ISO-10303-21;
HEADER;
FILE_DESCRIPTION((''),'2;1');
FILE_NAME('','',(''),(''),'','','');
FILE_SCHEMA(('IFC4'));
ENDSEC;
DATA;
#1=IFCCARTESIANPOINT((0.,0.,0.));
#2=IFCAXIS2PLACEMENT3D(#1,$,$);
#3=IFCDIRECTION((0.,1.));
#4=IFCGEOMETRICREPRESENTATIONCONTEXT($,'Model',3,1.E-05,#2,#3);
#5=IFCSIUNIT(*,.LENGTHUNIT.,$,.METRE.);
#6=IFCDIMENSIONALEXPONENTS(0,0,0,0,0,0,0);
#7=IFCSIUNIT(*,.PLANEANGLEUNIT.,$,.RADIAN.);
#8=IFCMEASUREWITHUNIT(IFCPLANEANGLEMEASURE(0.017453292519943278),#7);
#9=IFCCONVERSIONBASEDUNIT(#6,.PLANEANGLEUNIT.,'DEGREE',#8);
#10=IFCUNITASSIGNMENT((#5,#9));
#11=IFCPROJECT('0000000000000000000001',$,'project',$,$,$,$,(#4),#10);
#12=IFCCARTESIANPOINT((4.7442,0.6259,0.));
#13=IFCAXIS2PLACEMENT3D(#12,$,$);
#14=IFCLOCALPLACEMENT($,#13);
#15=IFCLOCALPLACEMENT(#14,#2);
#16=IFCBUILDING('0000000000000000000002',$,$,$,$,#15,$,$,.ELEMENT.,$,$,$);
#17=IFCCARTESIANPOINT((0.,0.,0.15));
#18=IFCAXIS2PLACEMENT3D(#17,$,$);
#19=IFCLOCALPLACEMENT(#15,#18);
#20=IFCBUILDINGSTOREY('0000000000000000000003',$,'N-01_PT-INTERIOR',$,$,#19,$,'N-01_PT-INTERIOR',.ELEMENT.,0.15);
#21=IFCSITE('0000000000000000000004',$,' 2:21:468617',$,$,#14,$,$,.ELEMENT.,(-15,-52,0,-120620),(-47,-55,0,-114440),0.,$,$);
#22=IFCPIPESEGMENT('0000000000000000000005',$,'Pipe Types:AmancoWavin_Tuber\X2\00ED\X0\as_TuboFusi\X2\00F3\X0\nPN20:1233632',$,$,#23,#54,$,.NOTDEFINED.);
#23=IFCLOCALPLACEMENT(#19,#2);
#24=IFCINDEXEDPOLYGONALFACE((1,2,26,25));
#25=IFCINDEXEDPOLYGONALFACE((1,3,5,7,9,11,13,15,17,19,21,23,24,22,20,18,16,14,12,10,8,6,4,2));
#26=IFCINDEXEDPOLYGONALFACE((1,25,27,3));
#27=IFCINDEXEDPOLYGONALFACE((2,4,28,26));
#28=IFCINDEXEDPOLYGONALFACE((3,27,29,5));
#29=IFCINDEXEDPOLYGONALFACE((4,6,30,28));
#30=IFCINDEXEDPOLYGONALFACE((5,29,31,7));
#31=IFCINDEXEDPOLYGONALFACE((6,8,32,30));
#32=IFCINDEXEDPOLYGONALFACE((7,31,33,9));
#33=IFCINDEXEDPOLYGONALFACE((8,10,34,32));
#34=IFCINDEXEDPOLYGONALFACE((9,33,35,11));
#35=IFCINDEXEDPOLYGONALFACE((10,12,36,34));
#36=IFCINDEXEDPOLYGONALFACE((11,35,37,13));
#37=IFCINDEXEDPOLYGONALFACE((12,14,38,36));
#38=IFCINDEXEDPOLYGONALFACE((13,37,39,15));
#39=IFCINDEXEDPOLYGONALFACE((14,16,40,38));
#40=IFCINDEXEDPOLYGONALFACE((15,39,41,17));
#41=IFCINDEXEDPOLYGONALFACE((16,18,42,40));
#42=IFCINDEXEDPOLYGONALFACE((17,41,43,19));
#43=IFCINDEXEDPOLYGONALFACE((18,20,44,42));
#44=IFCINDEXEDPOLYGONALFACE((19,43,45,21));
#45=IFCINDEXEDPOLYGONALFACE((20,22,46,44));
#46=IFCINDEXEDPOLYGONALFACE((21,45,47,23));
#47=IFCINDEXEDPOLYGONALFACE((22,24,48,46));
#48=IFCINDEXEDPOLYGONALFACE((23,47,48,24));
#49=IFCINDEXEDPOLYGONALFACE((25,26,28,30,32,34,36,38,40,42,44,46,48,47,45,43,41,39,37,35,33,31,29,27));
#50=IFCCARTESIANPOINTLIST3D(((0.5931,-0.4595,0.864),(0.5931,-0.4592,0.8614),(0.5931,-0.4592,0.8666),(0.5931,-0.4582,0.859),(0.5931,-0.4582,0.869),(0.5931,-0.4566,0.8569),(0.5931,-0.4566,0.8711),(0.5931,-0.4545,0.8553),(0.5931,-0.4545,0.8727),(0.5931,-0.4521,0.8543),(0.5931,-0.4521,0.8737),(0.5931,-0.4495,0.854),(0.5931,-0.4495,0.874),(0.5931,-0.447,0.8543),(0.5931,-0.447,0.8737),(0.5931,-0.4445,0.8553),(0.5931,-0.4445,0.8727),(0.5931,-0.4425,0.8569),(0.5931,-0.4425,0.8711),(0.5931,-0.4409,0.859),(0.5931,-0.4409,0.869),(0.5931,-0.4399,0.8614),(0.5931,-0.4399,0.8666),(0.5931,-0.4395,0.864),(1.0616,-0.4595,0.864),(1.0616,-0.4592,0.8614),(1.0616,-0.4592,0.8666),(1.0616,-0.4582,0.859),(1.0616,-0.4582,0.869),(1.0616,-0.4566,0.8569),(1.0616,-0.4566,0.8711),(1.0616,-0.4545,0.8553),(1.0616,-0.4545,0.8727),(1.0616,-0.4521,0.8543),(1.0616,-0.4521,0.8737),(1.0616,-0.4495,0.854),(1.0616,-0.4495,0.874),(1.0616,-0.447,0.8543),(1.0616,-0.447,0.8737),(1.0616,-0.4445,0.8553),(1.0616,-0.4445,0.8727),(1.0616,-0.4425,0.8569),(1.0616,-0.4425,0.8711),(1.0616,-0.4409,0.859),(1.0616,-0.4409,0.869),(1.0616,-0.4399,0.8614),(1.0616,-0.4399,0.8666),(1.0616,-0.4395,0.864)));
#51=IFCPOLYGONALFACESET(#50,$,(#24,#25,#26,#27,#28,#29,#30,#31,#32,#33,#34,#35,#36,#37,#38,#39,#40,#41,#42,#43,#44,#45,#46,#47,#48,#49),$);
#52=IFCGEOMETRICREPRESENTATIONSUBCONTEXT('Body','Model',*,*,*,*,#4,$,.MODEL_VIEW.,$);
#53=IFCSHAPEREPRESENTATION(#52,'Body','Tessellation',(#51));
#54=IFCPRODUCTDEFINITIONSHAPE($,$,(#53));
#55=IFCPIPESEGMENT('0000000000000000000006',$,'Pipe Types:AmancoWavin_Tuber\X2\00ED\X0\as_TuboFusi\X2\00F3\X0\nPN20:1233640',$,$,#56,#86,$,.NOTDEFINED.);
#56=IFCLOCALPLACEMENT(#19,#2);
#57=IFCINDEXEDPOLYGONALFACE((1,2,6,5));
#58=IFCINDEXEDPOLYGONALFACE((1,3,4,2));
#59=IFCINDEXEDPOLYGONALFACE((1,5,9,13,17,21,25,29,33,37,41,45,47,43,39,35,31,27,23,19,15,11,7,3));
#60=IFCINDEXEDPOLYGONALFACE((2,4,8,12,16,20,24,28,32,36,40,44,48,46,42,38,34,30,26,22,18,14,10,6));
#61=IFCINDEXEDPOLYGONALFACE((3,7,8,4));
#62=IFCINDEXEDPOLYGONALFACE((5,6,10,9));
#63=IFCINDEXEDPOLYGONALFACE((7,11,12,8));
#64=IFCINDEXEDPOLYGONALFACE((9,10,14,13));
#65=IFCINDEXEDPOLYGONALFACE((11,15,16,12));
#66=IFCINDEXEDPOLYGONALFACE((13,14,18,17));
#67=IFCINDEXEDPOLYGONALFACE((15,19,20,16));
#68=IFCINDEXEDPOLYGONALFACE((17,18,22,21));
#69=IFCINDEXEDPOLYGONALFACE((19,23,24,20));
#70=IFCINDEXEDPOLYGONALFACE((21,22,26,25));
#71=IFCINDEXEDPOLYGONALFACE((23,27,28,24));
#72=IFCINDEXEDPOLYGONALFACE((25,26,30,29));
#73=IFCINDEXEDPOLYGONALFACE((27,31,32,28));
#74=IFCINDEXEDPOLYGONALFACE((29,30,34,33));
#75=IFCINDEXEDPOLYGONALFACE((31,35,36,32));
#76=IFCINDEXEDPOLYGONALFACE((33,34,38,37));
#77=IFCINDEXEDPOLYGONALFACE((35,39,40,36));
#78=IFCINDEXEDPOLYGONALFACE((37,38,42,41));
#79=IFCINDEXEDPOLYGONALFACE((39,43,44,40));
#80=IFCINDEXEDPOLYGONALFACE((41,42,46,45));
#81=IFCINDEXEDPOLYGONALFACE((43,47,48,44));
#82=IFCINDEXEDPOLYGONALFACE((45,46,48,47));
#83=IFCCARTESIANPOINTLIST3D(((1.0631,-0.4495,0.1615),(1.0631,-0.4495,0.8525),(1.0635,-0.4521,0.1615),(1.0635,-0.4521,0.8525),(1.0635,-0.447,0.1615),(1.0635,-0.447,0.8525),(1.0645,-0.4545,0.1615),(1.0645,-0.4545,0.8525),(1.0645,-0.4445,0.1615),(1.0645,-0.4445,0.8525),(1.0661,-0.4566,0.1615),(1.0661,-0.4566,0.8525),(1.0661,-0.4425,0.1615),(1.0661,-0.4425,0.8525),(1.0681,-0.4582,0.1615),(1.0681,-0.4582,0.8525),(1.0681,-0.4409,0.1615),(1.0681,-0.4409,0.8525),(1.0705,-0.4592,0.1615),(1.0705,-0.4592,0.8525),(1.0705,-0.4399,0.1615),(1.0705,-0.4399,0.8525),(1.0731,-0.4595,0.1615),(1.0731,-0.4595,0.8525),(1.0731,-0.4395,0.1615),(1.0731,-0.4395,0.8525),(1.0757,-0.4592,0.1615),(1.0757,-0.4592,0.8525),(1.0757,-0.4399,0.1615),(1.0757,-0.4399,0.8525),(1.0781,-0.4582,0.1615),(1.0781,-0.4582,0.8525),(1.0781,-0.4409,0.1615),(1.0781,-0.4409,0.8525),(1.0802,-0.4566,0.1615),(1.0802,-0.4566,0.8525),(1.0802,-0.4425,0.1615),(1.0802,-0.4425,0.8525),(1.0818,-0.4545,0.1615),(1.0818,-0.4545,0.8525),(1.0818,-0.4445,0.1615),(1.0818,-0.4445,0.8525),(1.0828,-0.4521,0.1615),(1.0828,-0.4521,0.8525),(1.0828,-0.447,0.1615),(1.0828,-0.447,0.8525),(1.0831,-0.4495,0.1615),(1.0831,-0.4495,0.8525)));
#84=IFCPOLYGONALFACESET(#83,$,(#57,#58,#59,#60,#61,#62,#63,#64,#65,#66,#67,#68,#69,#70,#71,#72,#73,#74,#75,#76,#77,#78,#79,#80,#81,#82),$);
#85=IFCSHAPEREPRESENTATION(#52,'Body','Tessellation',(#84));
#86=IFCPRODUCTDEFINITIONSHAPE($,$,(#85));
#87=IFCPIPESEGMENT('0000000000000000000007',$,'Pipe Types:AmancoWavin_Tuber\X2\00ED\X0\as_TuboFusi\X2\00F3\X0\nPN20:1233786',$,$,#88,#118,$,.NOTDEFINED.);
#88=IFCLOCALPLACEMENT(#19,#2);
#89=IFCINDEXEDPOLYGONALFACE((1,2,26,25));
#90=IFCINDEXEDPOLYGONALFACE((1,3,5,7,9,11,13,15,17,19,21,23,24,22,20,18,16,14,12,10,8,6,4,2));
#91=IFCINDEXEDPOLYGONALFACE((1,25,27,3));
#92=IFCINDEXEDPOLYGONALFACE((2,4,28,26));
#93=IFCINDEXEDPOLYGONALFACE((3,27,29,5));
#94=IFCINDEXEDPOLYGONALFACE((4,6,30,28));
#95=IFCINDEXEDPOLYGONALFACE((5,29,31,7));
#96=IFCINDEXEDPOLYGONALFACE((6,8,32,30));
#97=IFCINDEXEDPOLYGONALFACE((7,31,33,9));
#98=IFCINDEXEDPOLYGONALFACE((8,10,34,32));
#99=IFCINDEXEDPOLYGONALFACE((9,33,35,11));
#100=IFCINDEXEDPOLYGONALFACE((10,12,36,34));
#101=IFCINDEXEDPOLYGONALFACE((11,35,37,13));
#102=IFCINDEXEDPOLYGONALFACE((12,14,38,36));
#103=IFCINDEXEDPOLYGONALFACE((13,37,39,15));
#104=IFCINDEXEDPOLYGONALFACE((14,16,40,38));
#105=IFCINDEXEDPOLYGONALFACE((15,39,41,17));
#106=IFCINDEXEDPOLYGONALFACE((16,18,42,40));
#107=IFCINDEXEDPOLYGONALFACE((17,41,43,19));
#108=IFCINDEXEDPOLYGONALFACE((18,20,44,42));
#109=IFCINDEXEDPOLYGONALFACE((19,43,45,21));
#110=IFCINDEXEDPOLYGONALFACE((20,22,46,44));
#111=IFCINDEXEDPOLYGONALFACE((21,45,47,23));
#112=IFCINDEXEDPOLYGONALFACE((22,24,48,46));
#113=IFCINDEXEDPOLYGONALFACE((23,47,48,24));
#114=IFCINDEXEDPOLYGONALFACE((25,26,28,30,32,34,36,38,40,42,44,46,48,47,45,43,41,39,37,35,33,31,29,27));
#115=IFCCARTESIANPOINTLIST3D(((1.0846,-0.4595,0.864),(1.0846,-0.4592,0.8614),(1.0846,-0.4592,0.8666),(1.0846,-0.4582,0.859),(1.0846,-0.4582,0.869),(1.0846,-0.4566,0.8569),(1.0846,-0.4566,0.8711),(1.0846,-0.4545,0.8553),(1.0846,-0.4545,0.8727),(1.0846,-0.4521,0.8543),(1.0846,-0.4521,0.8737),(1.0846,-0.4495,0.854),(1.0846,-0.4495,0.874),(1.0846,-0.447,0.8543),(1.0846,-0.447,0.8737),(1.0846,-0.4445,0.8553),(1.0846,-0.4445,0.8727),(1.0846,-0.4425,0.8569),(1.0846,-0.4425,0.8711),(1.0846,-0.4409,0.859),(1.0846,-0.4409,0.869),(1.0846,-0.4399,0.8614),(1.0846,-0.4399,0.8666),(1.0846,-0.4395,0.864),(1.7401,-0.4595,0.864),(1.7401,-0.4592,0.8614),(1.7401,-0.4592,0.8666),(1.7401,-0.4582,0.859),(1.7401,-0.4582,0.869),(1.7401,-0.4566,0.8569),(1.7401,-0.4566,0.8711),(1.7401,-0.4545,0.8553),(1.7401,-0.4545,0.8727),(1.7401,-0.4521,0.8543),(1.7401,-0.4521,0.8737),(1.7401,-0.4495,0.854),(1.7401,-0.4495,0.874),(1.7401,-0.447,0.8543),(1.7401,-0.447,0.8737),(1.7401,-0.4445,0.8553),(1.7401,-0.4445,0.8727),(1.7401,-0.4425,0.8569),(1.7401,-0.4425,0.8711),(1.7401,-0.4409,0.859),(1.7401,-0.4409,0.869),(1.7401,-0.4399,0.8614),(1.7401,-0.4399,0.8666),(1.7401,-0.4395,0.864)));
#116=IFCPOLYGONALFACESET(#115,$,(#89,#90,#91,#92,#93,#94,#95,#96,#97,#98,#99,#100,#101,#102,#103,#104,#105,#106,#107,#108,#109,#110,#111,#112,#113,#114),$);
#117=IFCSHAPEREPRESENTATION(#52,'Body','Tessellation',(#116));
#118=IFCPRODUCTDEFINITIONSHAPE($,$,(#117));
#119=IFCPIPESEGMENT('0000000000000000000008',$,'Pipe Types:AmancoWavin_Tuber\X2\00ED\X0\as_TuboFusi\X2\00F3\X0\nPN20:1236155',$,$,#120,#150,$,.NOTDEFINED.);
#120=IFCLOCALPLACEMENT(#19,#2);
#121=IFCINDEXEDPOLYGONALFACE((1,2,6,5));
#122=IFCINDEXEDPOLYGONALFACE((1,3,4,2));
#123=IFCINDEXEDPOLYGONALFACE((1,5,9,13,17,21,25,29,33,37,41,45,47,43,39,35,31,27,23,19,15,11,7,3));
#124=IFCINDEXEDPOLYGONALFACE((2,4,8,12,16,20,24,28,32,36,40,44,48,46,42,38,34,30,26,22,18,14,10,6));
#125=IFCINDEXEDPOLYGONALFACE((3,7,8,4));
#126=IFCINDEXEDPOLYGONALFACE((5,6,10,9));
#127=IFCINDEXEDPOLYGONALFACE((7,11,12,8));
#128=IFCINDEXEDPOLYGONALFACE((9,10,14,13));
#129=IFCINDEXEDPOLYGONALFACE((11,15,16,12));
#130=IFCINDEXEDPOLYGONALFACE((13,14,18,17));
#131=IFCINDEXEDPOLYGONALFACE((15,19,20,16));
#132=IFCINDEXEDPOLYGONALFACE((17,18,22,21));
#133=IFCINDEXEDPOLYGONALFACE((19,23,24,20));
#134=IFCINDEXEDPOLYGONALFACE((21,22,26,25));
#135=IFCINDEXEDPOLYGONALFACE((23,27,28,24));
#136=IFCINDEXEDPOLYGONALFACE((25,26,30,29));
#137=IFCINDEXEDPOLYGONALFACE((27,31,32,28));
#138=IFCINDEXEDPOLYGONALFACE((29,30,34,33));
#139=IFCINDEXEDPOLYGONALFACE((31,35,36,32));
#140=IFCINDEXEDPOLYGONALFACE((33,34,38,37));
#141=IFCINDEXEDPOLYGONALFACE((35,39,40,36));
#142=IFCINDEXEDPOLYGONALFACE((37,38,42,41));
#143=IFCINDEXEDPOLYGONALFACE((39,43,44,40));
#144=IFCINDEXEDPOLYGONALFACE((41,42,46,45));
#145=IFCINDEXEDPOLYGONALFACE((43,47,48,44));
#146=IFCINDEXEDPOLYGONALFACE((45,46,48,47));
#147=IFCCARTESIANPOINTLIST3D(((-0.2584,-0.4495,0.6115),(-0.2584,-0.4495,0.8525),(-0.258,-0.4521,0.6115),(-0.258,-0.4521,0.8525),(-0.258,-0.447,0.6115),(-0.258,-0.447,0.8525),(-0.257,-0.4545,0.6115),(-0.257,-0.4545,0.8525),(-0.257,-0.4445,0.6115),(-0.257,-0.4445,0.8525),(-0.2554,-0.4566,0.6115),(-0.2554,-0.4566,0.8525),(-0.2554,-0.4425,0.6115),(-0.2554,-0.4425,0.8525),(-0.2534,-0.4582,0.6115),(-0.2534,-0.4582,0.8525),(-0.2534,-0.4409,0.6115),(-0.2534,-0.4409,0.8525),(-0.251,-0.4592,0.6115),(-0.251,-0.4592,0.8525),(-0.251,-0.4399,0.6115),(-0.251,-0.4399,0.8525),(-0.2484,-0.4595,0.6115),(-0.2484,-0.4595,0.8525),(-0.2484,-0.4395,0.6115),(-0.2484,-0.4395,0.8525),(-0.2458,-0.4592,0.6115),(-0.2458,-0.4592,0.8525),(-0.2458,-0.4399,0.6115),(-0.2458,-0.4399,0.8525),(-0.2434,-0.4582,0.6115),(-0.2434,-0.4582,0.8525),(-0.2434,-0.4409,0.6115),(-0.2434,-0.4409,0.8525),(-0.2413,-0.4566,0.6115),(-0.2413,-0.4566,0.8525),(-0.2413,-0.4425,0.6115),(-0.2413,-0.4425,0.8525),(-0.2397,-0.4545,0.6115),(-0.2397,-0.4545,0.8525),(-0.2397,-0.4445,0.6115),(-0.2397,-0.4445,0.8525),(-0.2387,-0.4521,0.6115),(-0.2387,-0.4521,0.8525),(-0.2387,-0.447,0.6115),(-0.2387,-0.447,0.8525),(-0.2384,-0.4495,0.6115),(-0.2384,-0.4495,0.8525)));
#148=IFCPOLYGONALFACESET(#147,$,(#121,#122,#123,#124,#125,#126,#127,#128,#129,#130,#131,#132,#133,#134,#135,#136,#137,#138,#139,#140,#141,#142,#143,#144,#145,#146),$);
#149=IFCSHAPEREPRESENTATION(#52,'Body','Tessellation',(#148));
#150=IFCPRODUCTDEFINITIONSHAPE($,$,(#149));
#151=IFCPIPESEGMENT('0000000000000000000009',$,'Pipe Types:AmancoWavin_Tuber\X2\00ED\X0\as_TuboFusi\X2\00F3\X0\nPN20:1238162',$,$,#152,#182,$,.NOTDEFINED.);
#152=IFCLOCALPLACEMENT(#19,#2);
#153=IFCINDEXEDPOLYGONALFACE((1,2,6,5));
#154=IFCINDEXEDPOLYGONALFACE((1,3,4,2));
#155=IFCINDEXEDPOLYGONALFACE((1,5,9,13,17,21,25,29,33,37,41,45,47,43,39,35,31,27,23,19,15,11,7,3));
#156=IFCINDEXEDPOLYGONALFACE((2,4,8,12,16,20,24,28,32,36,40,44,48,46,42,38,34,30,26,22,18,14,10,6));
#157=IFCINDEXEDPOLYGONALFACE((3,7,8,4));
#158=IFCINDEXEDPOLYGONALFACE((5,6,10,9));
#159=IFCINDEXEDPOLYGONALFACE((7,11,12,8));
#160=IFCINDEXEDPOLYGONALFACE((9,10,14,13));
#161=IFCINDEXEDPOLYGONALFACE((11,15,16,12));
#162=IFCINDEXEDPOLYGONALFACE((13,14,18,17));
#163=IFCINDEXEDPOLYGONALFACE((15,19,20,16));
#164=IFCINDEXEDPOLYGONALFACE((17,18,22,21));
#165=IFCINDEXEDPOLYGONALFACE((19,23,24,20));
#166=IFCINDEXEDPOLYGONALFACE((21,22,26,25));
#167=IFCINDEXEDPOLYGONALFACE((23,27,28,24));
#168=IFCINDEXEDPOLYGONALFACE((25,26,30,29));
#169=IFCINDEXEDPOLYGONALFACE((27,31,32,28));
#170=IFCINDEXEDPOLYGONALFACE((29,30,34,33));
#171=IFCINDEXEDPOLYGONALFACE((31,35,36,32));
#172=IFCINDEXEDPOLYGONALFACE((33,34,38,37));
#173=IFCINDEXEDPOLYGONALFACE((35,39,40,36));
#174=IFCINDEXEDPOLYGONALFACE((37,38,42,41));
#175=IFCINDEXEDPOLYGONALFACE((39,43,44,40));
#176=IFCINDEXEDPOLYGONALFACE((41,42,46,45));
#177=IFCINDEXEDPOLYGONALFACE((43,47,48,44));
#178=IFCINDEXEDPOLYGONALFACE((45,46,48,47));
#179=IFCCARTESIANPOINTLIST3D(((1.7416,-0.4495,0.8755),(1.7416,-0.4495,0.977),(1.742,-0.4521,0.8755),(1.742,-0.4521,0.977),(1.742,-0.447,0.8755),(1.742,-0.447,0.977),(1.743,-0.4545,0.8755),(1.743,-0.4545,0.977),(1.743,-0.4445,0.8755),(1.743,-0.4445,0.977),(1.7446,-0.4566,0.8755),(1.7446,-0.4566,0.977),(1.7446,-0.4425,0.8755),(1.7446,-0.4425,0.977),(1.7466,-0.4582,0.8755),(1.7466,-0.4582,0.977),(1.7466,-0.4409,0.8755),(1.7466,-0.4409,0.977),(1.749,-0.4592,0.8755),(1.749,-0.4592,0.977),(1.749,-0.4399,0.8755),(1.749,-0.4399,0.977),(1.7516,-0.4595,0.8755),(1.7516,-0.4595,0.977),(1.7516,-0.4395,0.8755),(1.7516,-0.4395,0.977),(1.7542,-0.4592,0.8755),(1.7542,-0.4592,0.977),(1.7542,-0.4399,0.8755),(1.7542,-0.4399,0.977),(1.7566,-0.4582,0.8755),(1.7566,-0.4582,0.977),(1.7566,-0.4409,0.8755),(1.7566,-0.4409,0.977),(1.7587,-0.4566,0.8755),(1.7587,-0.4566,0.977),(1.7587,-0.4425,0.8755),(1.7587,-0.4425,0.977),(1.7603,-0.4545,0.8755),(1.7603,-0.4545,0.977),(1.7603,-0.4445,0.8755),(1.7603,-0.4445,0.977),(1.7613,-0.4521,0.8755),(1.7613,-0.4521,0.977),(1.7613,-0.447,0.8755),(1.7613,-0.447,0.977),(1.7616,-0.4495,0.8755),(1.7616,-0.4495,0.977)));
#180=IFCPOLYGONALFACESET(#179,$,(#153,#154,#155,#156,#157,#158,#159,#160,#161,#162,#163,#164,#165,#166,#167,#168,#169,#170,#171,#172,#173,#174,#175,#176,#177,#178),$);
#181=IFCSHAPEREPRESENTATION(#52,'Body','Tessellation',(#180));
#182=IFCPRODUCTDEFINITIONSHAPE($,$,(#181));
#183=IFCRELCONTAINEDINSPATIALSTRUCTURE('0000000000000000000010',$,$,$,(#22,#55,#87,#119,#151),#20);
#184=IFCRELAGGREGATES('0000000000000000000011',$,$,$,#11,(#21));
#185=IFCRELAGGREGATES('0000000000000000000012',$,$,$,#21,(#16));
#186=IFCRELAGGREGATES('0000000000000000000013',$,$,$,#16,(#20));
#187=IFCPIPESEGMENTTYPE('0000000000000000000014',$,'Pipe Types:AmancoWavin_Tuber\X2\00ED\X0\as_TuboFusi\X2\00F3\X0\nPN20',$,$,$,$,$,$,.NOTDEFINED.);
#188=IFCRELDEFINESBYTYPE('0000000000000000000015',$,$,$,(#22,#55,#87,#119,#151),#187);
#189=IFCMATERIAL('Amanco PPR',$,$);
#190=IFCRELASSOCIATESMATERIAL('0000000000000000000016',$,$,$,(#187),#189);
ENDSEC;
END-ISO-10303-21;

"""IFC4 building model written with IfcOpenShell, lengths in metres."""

from ifc_helpers import new_model, entity, si_unit, converted_unit, direction, frame, origin, place, context, subcontext, project, spatial, arc, indexed_curve, outline, extrude, material, type_object, element, save


model = new_model("IFC4")

# Units and contexts
model_context = context("Model", 3, precision=1e-05, world=origin(), true_north=direction((0.0, 1.0)))
body_context = subcontext(model_context, "Body", "Model", "MODEL_VIEW")
ifc_project = project(units=[si_unit("LENGTHUNIT", "METRE"), converted_unit("PLANEANGLEUNIT", "DEGREE", entity("IfcPlaneAngleMeasure", 0.017453292519943278), si_unit("PLANEANGLEUNIT", "RADIAN"), dimensions=[0, 0, 0, 0, 0, 0, 0])], contexts=[model_context])

# Site, building, storey
site_placement = place(None, frame((4.7442, 0.6259, 0.0)))
site = spatial("IfcSite", under=ifc_project, at=site_placement, Name=" 2:21:468617", CompositionType="ELEMENT", RefLatitude=(-15, -52, 0, -120620), RefLongitude=(-47, -55, 0, -114440), RefElevation=0.0)
building_placement = place(site_placement, origin())
building = spatial("IfcBuilding", under=site, at=building_placement, CompositionType="ELEMENT")
storey_placement = place(building_placement, frame((0.0, 0.0, 0.15)))
storey = spatial("IfcBuildingStorey", under=building, at=storey_placement, Name="N-01_PT-INTERIOR", LongName="N-01_PT-INTERIOR", CompositionType="ELEMENT", Elevation=0.15)

# Pipe segments
ifc_material_1 = material(Name="Amanco PPR")
pipe_segment_type_1 = type_object("IfcPipeSegmentType", Name="Pipe Types:AmancoWavin_Tuberías_TuboFusiónPN20", PredefinedType="NOTDEFINED", material=ifc_material_1)
pipe_segment_1_placement = place(storey_placement, origin())
element("IfcPipeSegment", 1, at=pipe_segment_1_placement, inside=storey, type_object=pipe_segment_type_1, Name="Pipe Types:AmancoWavin_Tuberías_TuboFusiónPN20:1233632", PredefinedType="NOTDEFINED", context=body_context, shape_type="SweptSolid", body=[
    extrude(outline(indexed_curve([(0.01, 0.0), (0.0071, 0.0071), (0.0, 0.01), (-0.0071, 0.0071), (-0.01, 0.0), (-0.0071, -0.0071), (0.0, -0.01), (0.0071, -0.0071)], segments=[arc(1, 2, 3), arc(3, 4, 5), arc(5, 6, 7), arc(7, 8, 1)], self_intersect=False)), frame((0.5931, -0.4495, 0.864), z_axis=(1.0, 0.0, 0.0), x_axis=(0.0, -1.0, 0.0)), (0.0, 0.0, 1.0), 0.4685),
])
pipe_segment_2_placement = place(storey_placement, origin())
element("IfcPipeSegment", 2, at=pipe_segment_2_placement, inside=storey, type_object=pipe_segment_type_1, Name="Pipe Types:AmancoWavin_Tuberías_TuboFusiónPN20:1233640", PredefinedType="NOTDEFINED", context=body_context, shape_type="SweptSolid", body=[
    extrude(outline(indexed_curve([(0.01, 0.0), (0.0071, 0.0071), (0.0, 0.01), (-0.0071, 0.0071), (-0.01, 0.0), (-0.0071, -0.0071), (0.0, -0.01), (0.0071, -0.0071)], segments=[arc(1, 2, 3), arc(3, 4, 5), arc(5, 6, 7), arc(7, 8, 1)], self_intersect=False)), frame((1.0731, -0.4495, 0.1615)), (0.0, 0.0, 1.0), 0.691),
])
pipe_segment_3_placement = place(storey_placement, origin())
element("IfcPipeSegment", 3, at=pipe_segment_3_placement, inside=storey, type_object=pipe_segment_type_1, Name="Pipe Types:AmancoWavin_Tuberías_TuboFusiónPN20:1233786", PredefinedType="NOTDEFINED", context=body_context, shape_type="SweptSolid", body=[
    extrude(outline(indexed_curve([(0.01, 0.0), (0.0071, 0.0071), (0.0, 0.01), (-0.0071, 0.0071), (-0.01, 0.0), (-0.0071, -0.0071), (0.0, -0.01), (0.0071, -0.0071)], segments=[arc(1, 2, 3), arc(3, 4, 5), arc(5, 6, 7), arc(7, 8, 1)], self_intersect=False)), frame((1.0846, -0.4495, 0.864), z_axis=(1.0, 0.0, 0.0), x_axis=(0.0, -1.0, 0.0)), (0.0, 0.0, 1.0), 0.6555),
])
pipe_segment_4_placement = place(storey_placement, origin())
element("IfcPipeSegment", 4, at=pipe_segment_4_placement, inside=storey, type_object=pipe_segment_type_1, Name="Pipe Types:AmancoWavin_Tuberías_TuboFusiónPN20:1236155", PredefinedType="NOTDEFINED", context=body_context, shape_type="SweptSolid", body=[
    extrude(outline(indexed_curve([(0.01, 0.0), (0.0071, 0.0071), (0.0, 0.01), (-0.0071, 0.0071), (-0.01, 0.0), (-0.0071, -0.0071), (0.0, -0.01), (0.0071, -0.0071)], segments=[arc(1, 2, 3), arc(3, 4, 5), arc(5, 6, 7), arc(7, 8, 1)], self_intersect=False)), frame((-0.2484, -0.4495, 0.6115)), (0.0, 0.0, 1.0), 0.241),
])
pipe_segment_5_placement = place(storey_placement, origin())
element("IfcPipeSegment", 5, at=pipe_segment_5_placement, inside=storey, type_object=pipe_segment_type_1, Name="Pipe Types:AmancoWavin_Tuberías_TuboFusiónPN20:1238162", PredefinedType="NOTDEFINED", context=body_context, shape_type="SweptSolid", body=[
    extrude(outline(indexed_curve([(0.01, 0.0), (0.0071, 0.0071), (0.0, 0.01), (-0.0071, 0.0071), (-0.01, 0.0), (-0.0071, -0.0071), (0.0, -0.01), (0.0071, -0.0071)], segments=[arc(1, 2, 3), arc(3, 4, 5), arc(5, 6, 7), arc(7, 8, 1)], self_intersect=False)), frame((1.7516, -0.4495, 0.8755), z_axis=(0.0, 0.0, 1.0), x_axis=(-1.0, 0.0, 0.0)), (0.0, 0.0, 1.0), 0.1015),
])

save(model, "model.ifc")
